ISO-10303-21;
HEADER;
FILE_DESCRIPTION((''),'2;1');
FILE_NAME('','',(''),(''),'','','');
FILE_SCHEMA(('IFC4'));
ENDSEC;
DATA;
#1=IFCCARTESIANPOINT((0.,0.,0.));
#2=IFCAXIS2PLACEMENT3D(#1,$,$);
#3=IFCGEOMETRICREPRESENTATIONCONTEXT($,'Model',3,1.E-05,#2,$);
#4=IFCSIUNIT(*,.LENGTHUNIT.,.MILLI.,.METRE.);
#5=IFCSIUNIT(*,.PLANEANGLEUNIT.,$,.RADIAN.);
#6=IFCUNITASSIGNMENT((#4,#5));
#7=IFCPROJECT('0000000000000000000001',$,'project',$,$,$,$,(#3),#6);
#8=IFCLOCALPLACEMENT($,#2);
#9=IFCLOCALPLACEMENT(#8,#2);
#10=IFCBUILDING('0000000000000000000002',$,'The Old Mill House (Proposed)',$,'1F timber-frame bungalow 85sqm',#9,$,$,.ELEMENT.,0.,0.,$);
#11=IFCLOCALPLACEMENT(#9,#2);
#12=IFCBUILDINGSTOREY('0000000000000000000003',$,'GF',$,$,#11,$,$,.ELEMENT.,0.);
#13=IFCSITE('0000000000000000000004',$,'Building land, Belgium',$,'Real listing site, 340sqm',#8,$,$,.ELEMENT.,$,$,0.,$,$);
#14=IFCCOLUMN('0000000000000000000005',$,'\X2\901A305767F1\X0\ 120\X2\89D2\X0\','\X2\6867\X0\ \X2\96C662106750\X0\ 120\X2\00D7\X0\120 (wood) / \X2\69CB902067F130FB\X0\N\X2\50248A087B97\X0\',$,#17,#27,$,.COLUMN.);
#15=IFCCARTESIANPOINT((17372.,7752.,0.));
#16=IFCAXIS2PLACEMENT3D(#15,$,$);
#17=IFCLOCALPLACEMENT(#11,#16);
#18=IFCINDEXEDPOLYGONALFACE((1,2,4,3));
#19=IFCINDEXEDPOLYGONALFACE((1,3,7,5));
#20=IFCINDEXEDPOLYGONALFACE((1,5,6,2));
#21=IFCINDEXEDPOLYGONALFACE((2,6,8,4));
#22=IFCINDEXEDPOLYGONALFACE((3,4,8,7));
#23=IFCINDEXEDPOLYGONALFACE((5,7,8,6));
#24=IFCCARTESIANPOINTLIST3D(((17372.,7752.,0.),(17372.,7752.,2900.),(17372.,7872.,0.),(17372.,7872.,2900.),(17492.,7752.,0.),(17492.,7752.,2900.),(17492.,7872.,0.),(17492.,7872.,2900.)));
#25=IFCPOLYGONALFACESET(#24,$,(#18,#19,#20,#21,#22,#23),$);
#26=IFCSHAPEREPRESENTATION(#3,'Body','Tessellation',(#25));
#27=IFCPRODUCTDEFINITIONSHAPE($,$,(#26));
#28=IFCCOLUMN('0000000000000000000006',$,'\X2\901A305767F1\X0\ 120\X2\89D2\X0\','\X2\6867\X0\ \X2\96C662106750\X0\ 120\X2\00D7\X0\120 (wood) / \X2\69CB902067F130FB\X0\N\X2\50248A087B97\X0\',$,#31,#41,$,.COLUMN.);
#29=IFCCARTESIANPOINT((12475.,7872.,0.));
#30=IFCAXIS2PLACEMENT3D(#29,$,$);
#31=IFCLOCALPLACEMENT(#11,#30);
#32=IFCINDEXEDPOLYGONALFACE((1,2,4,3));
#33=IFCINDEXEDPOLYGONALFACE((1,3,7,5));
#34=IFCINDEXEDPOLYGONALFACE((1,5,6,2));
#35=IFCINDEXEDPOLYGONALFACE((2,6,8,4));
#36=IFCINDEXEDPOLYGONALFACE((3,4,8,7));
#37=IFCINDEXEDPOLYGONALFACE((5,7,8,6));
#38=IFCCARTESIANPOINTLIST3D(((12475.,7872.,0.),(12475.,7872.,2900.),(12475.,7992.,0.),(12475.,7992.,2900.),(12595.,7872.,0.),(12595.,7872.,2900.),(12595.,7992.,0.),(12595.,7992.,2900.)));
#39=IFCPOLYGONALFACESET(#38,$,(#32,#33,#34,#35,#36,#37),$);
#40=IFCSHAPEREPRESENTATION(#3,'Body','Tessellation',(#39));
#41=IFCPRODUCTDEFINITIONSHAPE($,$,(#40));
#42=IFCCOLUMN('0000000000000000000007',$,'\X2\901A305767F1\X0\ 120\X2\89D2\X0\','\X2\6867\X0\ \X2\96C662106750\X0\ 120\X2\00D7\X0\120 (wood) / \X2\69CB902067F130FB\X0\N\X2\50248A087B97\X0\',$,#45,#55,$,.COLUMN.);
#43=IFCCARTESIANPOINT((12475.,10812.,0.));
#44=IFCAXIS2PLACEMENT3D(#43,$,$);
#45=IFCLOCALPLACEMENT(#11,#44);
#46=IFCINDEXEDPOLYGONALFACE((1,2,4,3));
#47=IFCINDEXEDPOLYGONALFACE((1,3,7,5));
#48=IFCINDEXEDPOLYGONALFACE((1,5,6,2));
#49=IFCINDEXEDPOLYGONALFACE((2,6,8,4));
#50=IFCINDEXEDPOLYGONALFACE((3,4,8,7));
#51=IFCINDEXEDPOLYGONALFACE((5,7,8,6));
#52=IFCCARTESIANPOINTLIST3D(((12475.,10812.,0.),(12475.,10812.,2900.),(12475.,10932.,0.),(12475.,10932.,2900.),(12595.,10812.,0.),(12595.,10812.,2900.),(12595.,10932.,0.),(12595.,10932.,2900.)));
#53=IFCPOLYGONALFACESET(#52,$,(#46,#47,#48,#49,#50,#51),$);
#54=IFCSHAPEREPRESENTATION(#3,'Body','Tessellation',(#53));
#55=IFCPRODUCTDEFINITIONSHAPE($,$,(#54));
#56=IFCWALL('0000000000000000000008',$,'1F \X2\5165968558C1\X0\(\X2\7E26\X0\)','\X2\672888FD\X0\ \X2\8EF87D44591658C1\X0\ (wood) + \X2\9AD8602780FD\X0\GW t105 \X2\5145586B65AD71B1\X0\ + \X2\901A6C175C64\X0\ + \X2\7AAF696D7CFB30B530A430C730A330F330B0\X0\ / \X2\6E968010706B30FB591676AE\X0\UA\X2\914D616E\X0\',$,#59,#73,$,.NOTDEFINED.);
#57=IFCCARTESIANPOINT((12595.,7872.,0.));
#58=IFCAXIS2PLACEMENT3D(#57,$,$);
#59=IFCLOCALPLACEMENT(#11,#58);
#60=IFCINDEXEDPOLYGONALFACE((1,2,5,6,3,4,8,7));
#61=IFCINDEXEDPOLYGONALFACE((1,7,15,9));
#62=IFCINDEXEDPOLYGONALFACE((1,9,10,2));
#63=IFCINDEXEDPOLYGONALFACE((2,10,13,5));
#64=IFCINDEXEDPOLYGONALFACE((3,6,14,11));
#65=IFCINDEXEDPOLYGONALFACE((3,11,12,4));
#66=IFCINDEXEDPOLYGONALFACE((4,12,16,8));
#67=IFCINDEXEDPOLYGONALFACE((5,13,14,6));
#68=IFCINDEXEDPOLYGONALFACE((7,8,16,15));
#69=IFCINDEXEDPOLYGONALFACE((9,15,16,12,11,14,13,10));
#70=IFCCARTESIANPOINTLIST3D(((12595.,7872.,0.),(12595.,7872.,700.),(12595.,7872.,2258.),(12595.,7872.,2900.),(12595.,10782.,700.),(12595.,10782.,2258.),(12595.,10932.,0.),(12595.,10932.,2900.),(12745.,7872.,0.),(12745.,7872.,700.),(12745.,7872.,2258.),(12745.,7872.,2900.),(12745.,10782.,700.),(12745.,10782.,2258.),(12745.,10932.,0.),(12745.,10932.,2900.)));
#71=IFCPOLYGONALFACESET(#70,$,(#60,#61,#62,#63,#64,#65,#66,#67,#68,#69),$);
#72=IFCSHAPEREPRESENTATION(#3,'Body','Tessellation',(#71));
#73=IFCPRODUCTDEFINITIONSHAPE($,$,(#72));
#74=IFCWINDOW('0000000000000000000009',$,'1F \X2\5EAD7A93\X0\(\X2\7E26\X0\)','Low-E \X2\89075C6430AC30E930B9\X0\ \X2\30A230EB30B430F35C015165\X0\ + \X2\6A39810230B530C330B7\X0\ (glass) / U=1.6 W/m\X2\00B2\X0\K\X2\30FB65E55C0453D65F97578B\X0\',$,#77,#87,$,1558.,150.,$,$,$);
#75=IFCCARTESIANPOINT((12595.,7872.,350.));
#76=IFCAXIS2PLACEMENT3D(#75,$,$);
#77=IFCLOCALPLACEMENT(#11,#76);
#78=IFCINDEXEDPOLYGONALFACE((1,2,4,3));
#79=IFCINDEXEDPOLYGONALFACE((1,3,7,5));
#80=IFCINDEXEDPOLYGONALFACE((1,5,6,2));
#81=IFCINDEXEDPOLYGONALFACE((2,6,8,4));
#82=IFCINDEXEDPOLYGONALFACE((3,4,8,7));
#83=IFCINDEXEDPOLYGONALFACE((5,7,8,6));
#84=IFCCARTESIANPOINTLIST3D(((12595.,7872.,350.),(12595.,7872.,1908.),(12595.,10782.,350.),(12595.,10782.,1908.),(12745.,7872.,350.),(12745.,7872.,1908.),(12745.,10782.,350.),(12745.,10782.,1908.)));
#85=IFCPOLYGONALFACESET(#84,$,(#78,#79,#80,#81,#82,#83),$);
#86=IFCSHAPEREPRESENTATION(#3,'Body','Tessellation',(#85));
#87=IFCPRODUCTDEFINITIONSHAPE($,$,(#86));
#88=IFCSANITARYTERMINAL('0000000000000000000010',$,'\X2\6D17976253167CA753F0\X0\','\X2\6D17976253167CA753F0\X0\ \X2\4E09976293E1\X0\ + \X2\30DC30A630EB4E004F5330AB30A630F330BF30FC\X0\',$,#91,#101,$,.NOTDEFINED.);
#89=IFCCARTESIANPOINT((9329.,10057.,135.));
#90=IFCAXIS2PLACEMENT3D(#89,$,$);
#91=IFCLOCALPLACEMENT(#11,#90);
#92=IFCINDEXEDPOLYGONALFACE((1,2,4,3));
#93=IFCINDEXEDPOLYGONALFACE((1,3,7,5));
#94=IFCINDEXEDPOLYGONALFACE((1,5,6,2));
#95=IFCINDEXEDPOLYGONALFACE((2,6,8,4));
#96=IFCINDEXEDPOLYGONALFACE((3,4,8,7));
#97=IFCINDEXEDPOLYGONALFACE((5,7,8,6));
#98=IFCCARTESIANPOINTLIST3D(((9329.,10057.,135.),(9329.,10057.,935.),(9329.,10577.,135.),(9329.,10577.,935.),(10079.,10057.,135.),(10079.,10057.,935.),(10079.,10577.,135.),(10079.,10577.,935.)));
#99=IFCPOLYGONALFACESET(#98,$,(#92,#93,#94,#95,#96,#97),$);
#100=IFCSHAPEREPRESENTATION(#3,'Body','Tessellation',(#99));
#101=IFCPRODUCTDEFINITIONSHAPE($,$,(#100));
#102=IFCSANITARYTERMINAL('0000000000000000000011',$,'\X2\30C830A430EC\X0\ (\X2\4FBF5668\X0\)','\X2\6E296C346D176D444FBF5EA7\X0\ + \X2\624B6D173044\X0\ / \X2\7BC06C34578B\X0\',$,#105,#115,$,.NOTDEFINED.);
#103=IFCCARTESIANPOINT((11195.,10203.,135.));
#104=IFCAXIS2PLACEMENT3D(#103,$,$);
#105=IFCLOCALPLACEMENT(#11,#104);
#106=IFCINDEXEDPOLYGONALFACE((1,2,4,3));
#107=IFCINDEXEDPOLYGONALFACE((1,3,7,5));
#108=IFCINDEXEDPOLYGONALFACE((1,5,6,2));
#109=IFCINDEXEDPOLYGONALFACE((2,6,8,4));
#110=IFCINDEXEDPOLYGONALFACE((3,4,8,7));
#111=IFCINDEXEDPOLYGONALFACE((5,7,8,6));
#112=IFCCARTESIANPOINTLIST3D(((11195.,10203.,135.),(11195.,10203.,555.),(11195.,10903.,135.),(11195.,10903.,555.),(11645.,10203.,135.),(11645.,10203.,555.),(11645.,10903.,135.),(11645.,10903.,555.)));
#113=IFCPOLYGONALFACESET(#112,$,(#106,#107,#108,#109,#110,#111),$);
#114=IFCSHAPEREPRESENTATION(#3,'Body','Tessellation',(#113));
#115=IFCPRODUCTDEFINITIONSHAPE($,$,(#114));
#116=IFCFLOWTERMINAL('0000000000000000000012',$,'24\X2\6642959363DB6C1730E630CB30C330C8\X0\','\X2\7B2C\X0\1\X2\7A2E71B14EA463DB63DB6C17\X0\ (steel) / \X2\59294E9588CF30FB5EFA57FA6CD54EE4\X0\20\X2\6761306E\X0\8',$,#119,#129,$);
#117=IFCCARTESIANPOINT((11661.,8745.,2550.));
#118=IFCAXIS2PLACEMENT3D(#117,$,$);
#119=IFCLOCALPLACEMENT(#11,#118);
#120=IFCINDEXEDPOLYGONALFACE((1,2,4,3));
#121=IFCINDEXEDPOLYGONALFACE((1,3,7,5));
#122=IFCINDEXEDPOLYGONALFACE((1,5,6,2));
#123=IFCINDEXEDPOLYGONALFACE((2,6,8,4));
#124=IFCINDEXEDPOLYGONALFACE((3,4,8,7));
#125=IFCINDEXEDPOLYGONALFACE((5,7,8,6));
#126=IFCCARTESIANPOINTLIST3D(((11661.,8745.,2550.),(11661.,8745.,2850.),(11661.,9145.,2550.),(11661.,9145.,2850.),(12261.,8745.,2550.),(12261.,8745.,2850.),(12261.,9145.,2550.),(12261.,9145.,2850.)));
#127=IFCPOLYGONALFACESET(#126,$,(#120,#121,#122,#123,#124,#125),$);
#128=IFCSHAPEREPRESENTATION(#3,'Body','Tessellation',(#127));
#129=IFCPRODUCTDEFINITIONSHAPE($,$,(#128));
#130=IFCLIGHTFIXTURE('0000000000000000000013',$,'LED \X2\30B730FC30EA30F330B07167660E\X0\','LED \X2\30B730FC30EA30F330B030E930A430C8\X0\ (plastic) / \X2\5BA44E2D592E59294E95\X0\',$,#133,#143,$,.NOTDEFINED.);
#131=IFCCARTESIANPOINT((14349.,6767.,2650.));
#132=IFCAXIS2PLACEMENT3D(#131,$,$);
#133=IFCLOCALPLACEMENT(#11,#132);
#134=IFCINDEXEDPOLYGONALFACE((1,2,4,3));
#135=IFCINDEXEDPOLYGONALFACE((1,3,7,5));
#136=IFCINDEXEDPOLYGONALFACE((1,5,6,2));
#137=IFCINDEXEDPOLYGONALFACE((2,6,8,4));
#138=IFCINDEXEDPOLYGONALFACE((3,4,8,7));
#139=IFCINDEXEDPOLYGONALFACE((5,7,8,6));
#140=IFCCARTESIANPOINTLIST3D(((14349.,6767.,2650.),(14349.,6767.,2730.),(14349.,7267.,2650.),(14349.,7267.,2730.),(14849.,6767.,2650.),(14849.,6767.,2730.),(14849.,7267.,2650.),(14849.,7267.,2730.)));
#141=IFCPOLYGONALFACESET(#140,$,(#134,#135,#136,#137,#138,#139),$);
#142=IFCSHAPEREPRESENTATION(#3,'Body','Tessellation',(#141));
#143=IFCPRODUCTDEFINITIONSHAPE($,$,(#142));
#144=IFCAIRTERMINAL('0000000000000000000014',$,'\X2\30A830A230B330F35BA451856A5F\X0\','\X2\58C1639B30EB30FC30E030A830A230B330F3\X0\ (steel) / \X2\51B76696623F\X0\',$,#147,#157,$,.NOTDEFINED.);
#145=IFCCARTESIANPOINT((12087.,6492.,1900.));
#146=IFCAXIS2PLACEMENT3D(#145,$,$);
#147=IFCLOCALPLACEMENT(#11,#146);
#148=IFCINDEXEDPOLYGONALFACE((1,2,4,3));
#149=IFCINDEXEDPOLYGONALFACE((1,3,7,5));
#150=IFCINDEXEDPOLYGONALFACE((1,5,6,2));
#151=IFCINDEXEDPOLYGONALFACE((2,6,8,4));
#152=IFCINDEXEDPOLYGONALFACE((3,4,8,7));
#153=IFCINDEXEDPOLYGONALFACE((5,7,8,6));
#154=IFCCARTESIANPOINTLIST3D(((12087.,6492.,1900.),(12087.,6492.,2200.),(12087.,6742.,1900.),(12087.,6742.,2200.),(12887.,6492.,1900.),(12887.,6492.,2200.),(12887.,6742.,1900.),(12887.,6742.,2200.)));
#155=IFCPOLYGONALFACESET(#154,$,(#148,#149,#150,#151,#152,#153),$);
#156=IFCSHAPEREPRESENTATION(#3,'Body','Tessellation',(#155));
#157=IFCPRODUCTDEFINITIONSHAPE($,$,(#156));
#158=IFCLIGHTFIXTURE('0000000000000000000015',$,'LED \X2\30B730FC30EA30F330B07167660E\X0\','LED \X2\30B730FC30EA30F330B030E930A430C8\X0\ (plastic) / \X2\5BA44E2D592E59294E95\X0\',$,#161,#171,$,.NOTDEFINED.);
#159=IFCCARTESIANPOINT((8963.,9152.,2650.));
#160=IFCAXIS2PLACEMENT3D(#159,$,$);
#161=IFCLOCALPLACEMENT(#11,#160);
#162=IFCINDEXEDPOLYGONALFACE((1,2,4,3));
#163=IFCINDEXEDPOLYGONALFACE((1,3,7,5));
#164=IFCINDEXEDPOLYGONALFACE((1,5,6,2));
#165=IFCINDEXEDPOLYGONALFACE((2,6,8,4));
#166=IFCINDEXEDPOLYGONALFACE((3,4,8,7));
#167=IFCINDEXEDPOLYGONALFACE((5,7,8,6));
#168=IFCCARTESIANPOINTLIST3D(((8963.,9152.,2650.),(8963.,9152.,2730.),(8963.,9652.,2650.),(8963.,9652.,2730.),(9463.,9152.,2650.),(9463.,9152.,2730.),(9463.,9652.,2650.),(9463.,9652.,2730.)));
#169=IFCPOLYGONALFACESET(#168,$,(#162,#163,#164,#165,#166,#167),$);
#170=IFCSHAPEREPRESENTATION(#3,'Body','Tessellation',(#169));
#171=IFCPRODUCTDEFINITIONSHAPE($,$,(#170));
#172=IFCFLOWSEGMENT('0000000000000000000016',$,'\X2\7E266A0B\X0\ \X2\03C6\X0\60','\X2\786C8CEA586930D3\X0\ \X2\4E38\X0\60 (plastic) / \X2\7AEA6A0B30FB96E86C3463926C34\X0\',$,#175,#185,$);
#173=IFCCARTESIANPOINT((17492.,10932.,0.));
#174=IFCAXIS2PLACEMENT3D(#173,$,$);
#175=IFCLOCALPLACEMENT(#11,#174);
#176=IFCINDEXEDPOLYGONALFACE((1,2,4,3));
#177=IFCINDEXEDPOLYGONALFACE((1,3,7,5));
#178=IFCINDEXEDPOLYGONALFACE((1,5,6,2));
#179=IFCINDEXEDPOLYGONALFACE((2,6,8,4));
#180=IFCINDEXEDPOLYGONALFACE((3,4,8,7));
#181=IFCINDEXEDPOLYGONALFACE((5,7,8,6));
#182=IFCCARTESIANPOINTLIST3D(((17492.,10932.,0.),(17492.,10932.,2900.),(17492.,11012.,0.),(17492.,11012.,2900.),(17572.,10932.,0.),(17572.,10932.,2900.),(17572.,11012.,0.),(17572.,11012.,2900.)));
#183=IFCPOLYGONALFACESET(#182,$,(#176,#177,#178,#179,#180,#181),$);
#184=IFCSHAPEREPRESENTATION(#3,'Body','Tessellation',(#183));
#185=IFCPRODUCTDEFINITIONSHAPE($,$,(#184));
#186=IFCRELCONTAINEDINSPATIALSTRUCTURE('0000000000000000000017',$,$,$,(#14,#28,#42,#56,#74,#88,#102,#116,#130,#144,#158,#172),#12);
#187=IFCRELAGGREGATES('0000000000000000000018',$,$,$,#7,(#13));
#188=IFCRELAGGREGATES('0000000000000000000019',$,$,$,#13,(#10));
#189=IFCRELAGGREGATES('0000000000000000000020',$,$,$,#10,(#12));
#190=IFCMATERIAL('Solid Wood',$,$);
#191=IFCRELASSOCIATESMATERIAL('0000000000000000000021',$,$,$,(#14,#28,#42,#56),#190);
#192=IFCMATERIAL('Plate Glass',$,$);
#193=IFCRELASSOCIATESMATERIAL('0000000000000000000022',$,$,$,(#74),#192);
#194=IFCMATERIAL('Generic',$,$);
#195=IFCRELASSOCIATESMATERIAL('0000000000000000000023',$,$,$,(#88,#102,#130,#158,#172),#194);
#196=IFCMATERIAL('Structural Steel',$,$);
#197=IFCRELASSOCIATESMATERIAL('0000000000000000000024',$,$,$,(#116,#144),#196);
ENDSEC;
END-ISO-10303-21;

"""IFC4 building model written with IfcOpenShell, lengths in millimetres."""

from ifc_helpers import new_model, si_unit, frame, frame_2d, origin, place, context, project, spatial, rectangle, extrude, material, element, fill, save


model = new_model("IFC4")

# Units and contexts
model_context = context("Model", 3, precision=1e-05, world=origin())
ifc_project = project(units=[si_unit("LENGTHUNIT", "METRE", prefix="MILLI"), si_unit("PLANEANGLEUNIT", "RADIAN")], contexts=[model_context])

# Site, building, storey
site_placement = place(None, origin())
site = spatial("IfcSite", under=ifc_project, at=site_placement, Name="Building land, Belgium", ObjectType="Real listing site, 340sqm", CompositionType="ELEMENT", RefElevation=0.0)
building_placement = place(site_placement, origin())
building = spatial("IfcBuilding", under=site, at=building_placement, Name="The Old Mill House (Proposed)", ObjectType="1F timber-frame bungalow 85sqm", CompositionType="ELEMENT", ElevationOfRefHeight=0.0, ElevationOfTerrain=0.0)
storey_placement = place(building_placement, origin())
storey = spatial("IfcBuildingStorey", under=building, at=storey_placement, Name="GF", CompositionType="ELEMENT", Elevation=0.0)

# Columns
ifc_material_1 = material(Name="Solid Wood")
column_1_placement = place(storey_placement, frame((17372.0, 7752.0, 0.0)))
element("IfcColumn", 1, at=column_1_placement, inside=storey, material=ifc_material_1, Name="通し柱 120角", Description="桧 集成材 120×120 (wood) / 構造柱・N値計算", PredefinedType="COLUMN", context=model_context, shape_type="SweptSolid", body=[
    extrude(rectangle(XDim=120.0, YDim=120.0, at=frame_2d((60.0, 60.0))), frame((17372.0, 7752.0, 0.0)), (0.0, 0.0, 1.0), 2900.0),
])
column_2_placement = place(storey_placement, frame((12475.0, 7872.0, 0.0)))
element("IfcColumn", 2, at=column_2_placement, inside=storey, material=ifc_material_1, Name="通し柱 120角", Description="桧 集成材 120×120 (wood) / 構造柱・N値計算", PredefinedType="COLUMN", context=model_context, shape_type="SweptSolid", body=[
    extrude(rectangle(XDim=120.0, YDim=120.0, at=frame_2d((60.0, 60.0))), frame((12475.0, 7872.0, 0.0)), (0.0, 0.0, 1.0), 2900.0),
])
column_3_placement = place(storey_placement, frame((12475.0, 10812.0, 0.0)))
element("IfcColumn", 3, at=column_3_placement, inside=storey, material=ifc_material_1, Name="通し柱 120角", Description="桧 集成材 120×120 (wood) / 構造柱・N値計算", PredefinedType="COLUMN", context=model_context, shape_type="SweptSolid", body=[
    extrude(rectangle(XDim=120.0, YDim=120.0, at=frame_2d((60.0, 60.0))), frame((12475.0, 10812.0, 0.0)), (0.0, 0.0, 1.0), 2900.0),
])

# Wall, opening, window
wall_1_placement = place(storey_placement, frame((12595.0, 7872.0, 0.0)))
wall_1 = element("IfcWall", 4, at=wall_1_placement, inside=storey, material=ifc_material_1, Name="1F 入隅壁(縦)", Description="木製 軸組外壁 (wood) + 高性能GW t105 充填断熱 + 通気層 + 窯業系サイディング / 準耐火・外皮UA配慮", PredefinedType="NOTDEFINED", context=model_context, shape_type="SweptSolid", body=[
    extrude(rectangle(XDim=150.0, YDim=3060.0, at=frame_2d((75.0, 1530.0))), frame((12595.0, 7872.0, 0.0)), (0.0, 0.0, 1.0), 2900.0),
])
opening_placement = place(storey_placement, frame((12595.0, 7872.0, 350.0)))
opening = element("IfcOpeningElement", 5, at=opening_placement, cuts=wall_1, PredefinedType="NOTDEFINED", context=model_context, shape_type="SweptSolid", body=[
    extrude(rectangle(XDim=150.0, YDim=2910.0, at=frame_2d((75.0, 1455.0))), frame((12595.0, 7872.0, 350.0)), (0.0, 0.0, 1.0), 1558.0),
])
ifc_material_2 = material(Name="Plate Glass")
window_placement = place(storey_placement, frame((12595.0, 7872.0, 350.0)))
window = element("IfcWindow", 6, at=window_placement, inside=storey, material=ifc_material_2, Name="1F 庭窓(縦)", Description="Low-E 複層ガラス アルゴン封入 + 樹脂サッシ (glass) / U=1.6 W/m²K・日射取得型", OverallHeight=1558.0, OverallWidth=150.0, context=model_context, shape_type="SweptSolid", body=[
    extrude(rectangle(XDim=150.0, YDim=2910.0, at=frame_2d((75.0, 1455.0))), frame((12595.0, 7872.0, 350.0)), (0.0, 0.0, 1.0), 1558.0),
])
fill(opening, window)

# Sanitary terminals
ifc_material_3 = material(Name="Generic")
sanitary_terminal_1_placement = place(storey_placement, frame((9329.0, 10057.0, 135.0)))
element("IfcSanitaryTerminal", 7, at=sanitary_terminal_1_placement, inside=storey, material=ifc_material_3, Name="洗面化粧台", Description="洗面化粧台 三面鏡 + ボウル一体カウンター", PredefinedType="NOTDEFINED", context=model_context, shape_type="SweptSolid", body=[
    extrude(rectangle(XDim=750.0, YDim=520.0, at=frame_2d((375.0, 260.0))), frame((9329.0, 10057.0, 135.0)), (0.0, 0.0, 1.0), 800.0),
])
sanitary_terminal_2_placement = place(storey_placement, frame((11195.0, 10203.0, 135.0)))
element("IfcSanitaryTerminal", 8, at=sanitary_terminal_2_placement, inside=storey, material=ifc_material_3, Name="トイレ (便器)", Description="温水洗浄便座 + 手洗い / 節水型", PredefinedType="NOTDEFINED", context=model_context, shape_type="SweptSolid", body=[
    extrude(rectangle(XDim=450.0, YDim=700.0, at=frame_2d((225.0, 350.0))), frame((11195.0, 10203.0, 135.0)), (0.0, 0.0, 1.0), 420.0),
])

# Flow terminal
ifc_material_4 = material(Name="Structural Steel")
flow_terminal_placement = place(storey_placement, frame((11661.0, 8745.0, 2550.0)))
element("IfcFlowTerminal", 9, at=flow_terminal_placement, inside=storey, material=ifc_material_4, Name="24時間換気ユニット", Description="第1種熱交換換気 (steel) / 天井裏・建基法令20条の8", context=model_context, shape_type="SweptSolid", body=[
    extrude(rectangle(XDim=600.0, YDim=400.0, at=frame_2d((300.0, 200.0))), frame((11661.0, 8745.0, 2550.0)), (0.0, 0.0, 1.0), 300.0),
])

# Light fixture
light_fixture_1_placement = place(storey_placement, frame((14349.0, 6767.0, 2650.0)))
element("IfcLightFixture", 10, at=light_fixture_1_placement, inside=storey, material=ifc_material_3, Name="LED シーリング照明", Description="LED シーリングライト (plastic) / 室中央天井", PredefinedType="NOTDEFINED", context=model_context, shape_type="SweptSolid", body=[
    extrude(rectangle(XDim=500.0, YDim=500.0, at=frame_2d((250.0, 250.0))), frame((14349.0, 6767.0, 2650.0)), (0.0, 0.0, 1.0), 80.0),
])

# Air terminal
air_terminal_placement = place(storey_placement, frame((12087.0, 6492.0, 1900.0)))
element("IfcAirTerminal", 11, at=air_terminal_placement, inside=storey, material=ifc_material_4, Name="エアコン室内機", Description="壁掛ルームエアコン (steel) / 冷暖房", PredefinedType="NOTDEFINED", context=model_context, shape_type="SweptSolid", body=[
    extrude(rectangle(XDim=800.0, YDim=250.0, at=frame_2d((400.0, 125.0))), frame((12087.0, 6492.0, 1900.0)), (0.0, 0.0, 1.0), 300.0),
])

# Light fixture
light_fixture_2_placement = place(storey_placement, frame((8963.0, 9152.0, 2650.0)))
element("IfcLightFixture", 12, at=light_fixture_2_placement, inside=storey, material=ifc_material_3, Name="LED シーリング照明", Description="LED シーリングライト (plastic) / 室中央天井", PredefinedType="NOTDEFINED", context=model_context, shape_type="SweptSolid", body=[
    extrude(rectangle(XDim=500.0, YDim=500.0, at=frame_2d((250.0, 250.0))), frame((8963.0, 9152.0, 2650.0)), (0.0, 0.0, 1.0), 80.0),
])

# Flow segment
flow_segment_placement = place(storey_placement, frame((17492.0, 10932.0, 0.0)))
element("IfcFlowSegment", 13, at=flow_segment_placement, inside=storey, material=ifc_material_3, Name="縦樋 φ60", Description="硬質塩ビ 丸60 (plastic) / 竪樋・雨水排水", context=model_context, shape_type="SweptSolid", body=[
    extrude(rectangle(XDim=80.0, YDim=80.0, at=frame_2d((40.0, 40.0))), frame((17492.0, 10932.0, 0.0)), (0.0, 0.0, 1.0), 2900.0),
])

save(model, "model.ifc")
